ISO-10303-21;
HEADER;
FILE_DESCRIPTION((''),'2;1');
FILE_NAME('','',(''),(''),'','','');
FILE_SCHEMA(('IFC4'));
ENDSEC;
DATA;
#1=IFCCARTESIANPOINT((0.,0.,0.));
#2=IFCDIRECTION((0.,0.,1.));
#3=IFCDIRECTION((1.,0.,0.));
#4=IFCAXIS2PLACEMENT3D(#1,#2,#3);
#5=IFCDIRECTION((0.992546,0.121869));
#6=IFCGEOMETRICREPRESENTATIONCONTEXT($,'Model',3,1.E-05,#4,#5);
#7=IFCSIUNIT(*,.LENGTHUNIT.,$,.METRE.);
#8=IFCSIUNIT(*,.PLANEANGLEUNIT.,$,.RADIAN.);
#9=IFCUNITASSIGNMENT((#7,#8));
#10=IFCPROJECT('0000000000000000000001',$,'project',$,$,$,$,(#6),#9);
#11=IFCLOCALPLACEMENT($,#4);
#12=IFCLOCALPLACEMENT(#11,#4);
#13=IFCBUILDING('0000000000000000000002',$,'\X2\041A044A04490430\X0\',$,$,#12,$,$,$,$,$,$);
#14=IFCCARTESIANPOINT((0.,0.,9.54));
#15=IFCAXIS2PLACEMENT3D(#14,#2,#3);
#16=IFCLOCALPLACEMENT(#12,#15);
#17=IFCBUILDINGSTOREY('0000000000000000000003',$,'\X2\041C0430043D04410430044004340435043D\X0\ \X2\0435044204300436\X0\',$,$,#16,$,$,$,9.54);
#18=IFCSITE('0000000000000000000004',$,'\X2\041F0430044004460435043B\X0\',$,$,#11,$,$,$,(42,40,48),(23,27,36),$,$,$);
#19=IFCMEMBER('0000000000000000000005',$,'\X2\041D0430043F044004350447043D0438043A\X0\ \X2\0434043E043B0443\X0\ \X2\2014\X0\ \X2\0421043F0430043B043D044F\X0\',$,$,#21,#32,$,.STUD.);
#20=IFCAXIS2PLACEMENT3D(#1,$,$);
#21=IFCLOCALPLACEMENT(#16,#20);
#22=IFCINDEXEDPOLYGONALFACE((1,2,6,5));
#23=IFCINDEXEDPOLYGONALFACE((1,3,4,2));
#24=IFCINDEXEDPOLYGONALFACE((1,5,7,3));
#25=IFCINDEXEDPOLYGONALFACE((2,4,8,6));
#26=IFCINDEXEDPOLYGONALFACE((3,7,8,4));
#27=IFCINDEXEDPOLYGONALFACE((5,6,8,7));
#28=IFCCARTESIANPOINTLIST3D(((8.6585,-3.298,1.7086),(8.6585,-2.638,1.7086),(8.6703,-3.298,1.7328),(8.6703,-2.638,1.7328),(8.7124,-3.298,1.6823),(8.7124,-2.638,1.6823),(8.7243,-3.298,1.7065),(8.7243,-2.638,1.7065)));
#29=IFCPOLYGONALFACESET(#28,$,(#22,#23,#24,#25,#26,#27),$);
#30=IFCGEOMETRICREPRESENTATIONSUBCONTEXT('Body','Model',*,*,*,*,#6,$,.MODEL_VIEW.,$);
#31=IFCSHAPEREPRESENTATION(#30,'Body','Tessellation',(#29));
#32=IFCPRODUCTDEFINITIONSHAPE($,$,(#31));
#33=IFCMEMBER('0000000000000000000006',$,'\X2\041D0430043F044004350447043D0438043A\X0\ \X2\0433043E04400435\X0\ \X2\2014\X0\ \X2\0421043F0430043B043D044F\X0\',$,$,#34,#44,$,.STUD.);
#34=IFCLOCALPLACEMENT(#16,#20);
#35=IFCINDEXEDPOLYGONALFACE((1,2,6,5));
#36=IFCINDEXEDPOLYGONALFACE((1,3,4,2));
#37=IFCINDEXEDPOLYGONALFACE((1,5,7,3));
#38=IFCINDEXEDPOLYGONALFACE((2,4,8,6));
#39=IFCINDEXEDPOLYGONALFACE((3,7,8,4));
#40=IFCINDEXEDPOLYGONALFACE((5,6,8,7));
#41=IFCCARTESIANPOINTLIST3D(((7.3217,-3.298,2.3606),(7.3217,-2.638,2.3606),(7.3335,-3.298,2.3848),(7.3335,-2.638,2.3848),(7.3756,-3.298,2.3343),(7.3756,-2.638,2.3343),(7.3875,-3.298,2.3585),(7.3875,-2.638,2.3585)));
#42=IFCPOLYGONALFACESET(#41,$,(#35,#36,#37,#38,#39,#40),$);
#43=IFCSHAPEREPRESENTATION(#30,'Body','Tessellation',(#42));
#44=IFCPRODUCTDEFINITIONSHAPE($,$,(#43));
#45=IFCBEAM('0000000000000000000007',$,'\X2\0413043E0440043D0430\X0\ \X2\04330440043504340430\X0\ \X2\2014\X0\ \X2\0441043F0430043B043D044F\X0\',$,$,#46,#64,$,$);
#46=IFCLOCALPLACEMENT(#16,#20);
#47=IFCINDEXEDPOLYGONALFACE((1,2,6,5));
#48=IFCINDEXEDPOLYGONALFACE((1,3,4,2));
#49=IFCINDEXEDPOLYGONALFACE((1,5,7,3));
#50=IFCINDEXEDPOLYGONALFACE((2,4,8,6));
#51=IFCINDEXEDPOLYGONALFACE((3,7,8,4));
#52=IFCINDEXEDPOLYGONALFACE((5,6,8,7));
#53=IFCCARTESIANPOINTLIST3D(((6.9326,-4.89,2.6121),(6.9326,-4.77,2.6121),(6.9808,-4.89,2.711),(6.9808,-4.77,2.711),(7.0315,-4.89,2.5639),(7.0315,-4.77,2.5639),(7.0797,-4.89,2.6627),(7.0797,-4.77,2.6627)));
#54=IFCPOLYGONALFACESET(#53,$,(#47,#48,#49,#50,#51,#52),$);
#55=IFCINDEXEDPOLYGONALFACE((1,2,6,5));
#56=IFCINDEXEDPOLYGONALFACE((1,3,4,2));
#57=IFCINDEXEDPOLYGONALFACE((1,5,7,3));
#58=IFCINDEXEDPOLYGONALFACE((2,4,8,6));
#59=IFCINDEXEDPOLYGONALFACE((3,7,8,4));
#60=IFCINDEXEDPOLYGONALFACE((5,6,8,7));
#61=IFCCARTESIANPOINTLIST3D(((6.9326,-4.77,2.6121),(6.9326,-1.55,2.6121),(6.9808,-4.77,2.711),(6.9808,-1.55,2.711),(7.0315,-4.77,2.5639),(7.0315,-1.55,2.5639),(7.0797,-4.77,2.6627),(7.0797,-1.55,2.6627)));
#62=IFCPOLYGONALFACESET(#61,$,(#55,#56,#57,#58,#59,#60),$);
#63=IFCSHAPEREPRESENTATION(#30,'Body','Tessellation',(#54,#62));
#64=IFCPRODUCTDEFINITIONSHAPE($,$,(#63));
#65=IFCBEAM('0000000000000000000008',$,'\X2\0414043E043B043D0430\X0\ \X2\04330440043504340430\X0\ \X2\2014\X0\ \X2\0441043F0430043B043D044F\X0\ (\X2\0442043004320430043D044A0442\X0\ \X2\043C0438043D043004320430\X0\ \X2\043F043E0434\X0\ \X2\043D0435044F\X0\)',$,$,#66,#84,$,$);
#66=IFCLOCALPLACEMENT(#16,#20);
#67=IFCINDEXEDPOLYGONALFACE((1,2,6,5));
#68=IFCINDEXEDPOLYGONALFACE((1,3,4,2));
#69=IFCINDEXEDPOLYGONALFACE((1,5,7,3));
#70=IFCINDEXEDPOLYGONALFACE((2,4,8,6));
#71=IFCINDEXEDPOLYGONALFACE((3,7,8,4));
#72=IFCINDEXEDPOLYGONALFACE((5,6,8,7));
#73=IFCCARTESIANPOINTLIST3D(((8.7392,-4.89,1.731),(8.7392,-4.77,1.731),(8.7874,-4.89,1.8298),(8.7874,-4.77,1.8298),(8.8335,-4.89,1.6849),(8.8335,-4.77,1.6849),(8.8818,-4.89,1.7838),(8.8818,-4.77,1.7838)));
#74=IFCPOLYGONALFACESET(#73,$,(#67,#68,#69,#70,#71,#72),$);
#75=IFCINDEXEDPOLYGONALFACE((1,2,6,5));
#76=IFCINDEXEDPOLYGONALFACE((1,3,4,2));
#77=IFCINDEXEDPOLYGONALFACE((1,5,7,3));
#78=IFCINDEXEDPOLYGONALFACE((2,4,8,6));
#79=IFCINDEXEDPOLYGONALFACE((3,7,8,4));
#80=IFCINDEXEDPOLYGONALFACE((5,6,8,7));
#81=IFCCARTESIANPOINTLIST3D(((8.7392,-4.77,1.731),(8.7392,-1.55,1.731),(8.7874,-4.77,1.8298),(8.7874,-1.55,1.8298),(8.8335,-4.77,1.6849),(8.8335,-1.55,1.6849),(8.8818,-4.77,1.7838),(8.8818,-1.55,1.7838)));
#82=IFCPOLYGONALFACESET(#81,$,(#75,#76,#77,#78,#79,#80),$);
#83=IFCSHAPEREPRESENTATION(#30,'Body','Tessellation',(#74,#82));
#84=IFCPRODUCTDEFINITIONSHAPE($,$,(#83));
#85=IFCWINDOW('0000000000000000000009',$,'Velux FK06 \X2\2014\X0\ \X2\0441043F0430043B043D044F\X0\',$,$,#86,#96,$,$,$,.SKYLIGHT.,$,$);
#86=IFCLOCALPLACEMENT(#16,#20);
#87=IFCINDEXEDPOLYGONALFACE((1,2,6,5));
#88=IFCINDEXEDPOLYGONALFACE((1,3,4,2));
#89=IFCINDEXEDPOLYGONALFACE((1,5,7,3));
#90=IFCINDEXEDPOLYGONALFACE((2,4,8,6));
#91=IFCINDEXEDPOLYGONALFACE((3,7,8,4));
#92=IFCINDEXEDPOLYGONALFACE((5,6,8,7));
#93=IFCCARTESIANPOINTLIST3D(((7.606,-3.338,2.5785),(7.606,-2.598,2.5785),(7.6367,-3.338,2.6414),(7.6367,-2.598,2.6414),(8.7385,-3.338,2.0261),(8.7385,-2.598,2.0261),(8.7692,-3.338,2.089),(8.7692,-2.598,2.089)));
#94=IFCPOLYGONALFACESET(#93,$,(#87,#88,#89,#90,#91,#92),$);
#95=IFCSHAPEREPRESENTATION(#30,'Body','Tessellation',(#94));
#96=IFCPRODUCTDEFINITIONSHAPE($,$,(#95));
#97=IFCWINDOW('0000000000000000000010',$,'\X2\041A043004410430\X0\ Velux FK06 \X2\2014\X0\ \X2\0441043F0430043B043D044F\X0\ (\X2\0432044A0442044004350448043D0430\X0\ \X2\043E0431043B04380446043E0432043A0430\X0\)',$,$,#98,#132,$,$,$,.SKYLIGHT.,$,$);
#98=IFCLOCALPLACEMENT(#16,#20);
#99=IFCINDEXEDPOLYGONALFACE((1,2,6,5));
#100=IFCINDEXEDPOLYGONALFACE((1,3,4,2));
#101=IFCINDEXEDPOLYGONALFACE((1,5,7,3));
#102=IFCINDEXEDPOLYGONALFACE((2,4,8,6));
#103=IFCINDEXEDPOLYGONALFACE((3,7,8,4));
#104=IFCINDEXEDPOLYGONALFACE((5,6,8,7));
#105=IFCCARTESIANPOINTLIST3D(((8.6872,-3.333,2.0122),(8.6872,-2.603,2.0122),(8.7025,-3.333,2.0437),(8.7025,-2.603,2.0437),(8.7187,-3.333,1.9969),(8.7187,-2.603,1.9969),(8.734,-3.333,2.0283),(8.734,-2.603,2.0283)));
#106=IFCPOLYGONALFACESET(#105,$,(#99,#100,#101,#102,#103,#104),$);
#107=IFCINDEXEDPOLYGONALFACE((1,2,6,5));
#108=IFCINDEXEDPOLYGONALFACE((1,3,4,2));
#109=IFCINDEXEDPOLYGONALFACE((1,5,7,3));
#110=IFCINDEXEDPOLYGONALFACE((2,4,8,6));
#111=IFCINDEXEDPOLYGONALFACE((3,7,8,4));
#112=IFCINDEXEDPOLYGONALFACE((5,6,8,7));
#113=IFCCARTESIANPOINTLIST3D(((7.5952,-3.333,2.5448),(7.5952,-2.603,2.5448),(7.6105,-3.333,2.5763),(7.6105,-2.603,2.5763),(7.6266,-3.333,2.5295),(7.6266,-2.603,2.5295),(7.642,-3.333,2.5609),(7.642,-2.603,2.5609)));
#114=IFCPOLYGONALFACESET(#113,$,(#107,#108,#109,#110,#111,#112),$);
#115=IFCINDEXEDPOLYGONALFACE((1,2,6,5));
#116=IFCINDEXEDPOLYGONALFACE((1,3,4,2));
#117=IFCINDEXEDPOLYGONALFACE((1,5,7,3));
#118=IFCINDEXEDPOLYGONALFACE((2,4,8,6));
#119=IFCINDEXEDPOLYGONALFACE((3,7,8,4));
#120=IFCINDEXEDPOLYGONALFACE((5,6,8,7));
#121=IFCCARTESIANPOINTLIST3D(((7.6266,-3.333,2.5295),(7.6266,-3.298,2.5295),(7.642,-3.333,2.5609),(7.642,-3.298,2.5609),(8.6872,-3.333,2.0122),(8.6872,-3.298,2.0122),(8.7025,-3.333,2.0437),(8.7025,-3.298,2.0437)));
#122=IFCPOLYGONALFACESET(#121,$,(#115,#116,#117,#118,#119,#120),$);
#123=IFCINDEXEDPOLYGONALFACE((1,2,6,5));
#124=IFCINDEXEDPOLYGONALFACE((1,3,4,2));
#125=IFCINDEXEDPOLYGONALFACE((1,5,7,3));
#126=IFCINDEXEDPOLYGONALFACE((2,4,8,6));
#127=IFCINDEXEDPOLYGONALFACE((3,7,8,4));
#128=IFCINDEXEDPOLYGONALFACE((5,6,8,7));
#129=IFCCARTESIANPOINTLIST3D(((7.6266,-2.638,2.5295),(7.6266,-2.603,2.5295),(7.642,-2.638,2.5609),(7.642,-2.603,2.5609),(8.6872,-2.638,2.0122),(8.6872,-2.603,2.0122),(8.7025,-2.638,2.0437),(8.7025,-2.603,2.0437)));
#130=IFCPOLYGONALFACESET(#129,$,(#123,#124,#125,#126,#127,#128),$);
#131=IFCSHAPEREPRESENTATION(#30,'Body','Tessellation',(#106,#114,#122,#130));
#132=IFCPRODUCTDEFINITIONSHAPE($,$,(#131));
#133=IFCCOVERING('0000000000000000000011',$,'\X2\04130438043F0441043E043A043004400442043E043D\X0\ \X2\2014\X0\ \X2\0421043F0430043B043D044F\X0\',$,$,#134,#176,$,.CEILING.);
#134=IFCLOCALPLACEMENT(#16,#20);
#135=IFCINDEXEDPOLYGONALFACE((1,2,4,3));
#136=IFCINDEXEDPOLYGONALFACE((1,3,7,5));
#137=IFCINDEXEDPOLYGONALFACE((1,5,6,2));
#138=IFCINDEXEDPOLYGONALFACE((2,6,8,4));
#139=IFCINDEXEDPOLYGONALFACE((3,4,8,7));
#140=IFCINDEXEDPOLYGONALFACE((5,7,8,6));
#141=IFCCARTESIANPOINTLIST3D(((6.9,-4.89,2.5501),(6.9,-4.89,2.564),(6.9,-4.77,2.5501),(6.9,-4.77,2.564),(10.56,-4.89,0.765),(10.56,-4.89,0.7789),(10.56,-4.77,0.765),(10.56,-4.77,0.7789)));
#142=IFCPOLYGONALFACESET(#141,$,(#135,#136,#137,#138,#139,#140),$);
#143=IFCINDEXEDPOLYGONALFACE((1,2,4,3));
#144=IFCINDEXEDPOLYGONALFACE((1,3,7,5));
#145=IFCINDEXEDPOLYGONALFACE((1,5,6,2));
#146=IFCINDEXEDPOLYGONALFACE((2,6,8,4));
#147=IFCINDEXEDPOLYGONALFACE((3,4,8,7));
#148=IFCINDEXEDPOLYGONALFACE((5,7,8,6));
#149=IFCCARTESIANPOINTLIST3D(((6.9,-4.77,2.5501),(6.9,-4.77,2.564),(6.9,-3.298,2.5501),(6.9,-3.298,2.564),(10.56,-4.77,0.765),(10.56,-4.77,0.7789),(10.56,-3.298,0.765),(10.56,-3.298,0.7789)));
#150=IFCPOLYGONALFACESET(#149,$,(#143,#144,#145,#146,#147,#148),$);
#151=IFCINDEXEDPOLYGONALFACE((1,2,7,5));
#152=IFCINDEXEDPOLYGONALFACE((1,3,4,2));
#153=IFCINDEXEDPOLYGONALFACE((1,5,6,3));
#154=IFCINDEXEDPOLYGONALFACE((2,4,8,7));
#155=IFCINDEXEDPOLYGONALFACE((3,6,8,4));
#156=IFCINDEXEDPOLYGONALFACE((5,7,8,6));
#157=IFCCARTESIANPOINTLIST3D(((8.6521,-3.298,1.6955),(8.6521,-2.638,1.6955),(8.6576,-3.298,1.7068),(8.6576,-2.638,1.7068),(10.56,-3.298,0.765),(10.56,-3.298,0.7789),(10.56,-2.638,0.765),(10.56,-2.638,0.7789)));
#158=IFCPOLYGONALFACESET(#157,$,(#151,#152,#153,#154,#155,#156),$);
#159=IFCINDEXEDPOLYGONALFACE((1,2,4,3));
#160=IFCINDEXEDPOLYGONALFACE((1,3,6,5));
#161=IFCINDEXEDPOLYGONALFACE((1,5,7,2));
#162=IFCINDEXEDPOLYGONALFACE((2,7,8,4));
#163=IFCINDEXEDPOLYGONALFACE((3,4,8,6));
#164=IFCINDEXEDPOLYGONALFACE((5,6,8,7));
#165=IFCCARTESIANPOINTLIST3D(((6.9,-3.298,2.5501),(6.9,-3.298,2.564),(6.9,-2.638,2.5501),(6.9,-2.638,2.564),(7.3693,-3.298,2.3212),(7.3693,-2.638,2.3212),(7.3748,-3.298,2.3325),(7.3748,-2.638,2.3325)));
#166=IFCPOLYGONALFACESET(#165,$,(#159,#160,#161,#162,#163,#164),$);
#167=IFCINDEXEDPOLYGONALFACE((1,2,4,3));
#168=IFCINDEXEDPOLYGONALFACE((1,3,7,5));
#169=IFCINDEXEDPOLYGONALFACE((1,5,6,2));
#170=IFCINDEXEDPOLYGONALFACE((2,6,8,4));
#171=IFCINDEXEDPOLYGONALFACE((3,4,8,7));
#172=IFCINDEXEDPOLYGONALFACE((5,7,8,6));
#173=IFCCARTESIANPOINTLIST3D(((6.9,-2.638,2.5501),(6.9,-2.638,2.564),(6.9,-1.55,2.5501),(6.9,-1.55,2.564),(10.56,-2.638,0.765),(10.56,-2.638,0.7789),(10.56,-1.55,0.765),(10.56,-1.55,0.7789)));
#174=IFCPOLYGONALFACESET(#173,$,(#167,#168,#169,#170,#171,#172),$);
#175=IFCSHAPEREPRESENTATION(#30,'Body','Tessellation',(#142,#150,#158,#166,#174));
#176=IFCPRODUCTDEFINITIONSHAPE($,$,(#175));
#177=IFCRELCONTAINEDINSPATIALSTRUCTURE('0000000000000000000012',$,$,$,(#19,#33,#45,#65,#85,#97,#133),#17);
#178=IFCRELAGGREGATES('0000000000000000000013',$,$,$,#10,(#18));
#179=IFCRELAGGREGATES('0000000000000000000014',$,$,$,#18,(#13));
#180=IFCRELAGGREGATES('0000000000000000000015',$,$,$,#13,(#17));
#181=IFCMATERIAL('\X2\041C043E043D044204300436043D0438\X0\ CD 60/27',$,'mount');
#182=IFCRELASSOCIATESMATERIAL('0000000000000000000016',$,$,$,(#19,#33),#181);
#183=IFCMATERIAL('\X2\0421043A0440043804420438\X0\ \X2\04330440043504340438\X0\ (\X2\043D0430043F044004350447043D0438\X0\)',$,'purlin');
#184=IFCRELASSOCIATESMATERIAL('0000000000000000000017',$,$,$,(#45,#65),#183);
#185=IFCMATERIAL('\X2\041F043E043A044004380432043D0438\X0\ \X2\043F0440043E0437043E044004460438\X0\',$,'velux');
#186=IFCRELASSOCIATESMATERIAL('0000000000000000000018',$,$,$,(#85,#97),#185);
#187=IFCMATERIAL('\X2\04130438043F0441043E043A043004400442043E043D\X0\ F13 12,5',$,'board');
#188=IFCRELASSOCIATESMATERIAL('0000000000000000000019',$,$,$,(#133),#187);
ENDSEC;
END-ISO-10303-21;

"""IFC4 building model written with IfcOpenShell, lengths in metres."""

from ifc_helpers import new_model, si_unit, direction, frame, origin_with_axes, place, context, subcontext, project, spatial, polyline, outline, extrude, material, element, save


model = new_model("IFC4")

# Units and contexts
model_context = context("Model", 3, precision=1e-05, world=origin_with_axes(), true_north=direction((0.992546, 0.121869)))
body_context = subcontext(model_context, "Body", "Model", "MODEL_VIEW")
ifc_project = project(units=[si_unit("LENGTHUNIT", "METRE"), si_unit("PLANEANGLEUNIT", "RADIAN")], contexts=[model_context])

# Site, building, storey
site_placement = place(None, origin_with_axes())
site = spatial("IfcSite", under=ifc_project, at=site_placement, Name="Парцел", RefLatitude=(42, 40, 48), RefLongitude=(23, 27, 36))
building_placement = place(site_placement, origin_with_axes())
building = spatial("IfcBuilding", under=site, at=building_placement, Name="Къща")
storey_placement = place(building_placement, frame((0.0, 0.0, 9.54), z_axis=(0.0, 0.0, 1.0), x_axis=(1.0, 0.0, 0.0)))
storey = spatial("IfcBuildingStorey", under=building, at=storey_placement, Name="Мансарден етаж", Elevation=9.54)

# Members
ifc_material_1 = material(Name="Монтажни CD 60/27", Category="mount")
member_1_placement = place(storey_placement, origin_with_axes())
element("IfcMember", 1, at=member_1_placement, inside=storey, material=ifc_material_1, Name="Напречник долу — Спалня", PredefinedType="STUD", context=body_context, shape_type="SweptSolid", body=[
    extrude(outline(polyline([(8.7124, -1.6823), (8.6585, -1.7086), (8.6703, -1.7328), (8.7243, -1.7065), (8.7124, -1.6823)])), frame((0.0, -3.298, 0.0), z_axis=(0.0, 1.0, 0.0), x_axis=(1.0, 0.0, 0.0)), (0.0, 0.0, 1.0), 0.66),
])
member_2_placement = place(storey_placement, origin_with_axes())
element("IfcMember", 2, at=member_2_placement, inside=storey, material=ifc_material_1, Name="Напречник горе — Спалня", PredefinedType="STUD", context=body_context, shape_type="SweptSolid", body=[
    extrude(outline(polyline([(7.3756, -2.3342), (7.3217, -2.3606), (7.3335, -2.3848), (7.3875, -2.3585), (7.3756, -2.3342)])), frame((0.0, -3.298, 0.0), z_axis=(0.0, 1.0, 0.0), x_axis=(1.0, 0.0, 0.0)), (0.0, 0.0, 1.0), 0.66),
])

# Beams
ifc_material_2 = material(Name="Скрити греди (напречни)", Category="purlin")
beam_1_placement = place(storey_placement, origin_with_axes())
element("IfcBeam", 3, at=beam_1_placement, inside=storey, material=ifc_material_2, Name="Горна греда — спалня", context=body_context, shape_type="SweptSolid", body=[
    extrude(outline(polyline([(7.0315, -2.5639), (6.9326, -2.6121), (6.9808, -2.711), (7.0797, -2.6627), (7.0315, -2.5639)])), frame((0.0, -4.89, 0.0), z_axis=(0.0, 1.0, 0.0), x_axis=(1.0, 0.0, 0.0)), (0.0, 0.0, 1.0), 0.12),
    extrude(outline(polyline([(7.0315, -2.5639), (6.9326, -2.6121), (6.9808, -2.711), (7.0797, -2.6627), (7.0315, -2.5639)])), frame((0.0, -4.77, 0.0), z_axis=(0.0, 1.0, 0.0), x_axis=(1.0, 0.0, 0.0)), (0.0, 0.0, 1.0), 3.22),
])
beam_2_placement = place(storey_placement, origin_with_axes())
element("IfcBeam", 4, at=beam_2_placement, inside=storey, material=ifc_material_2, Name="Долна греда — спалня (таванът минава под нея)", context=body_context, shape_type="SweptSolid", body=[
    extrude(outline(polyline([(8.8335, -1.6849), (8.7392, -1.731), (8.7874, -1.8298), (8.8818, -1.7838), (8.8335, -1.6849)])), frame((0.0, -4.89, 0.0), z_axis=(0.0, 1.0, 0.0), x_axis=(1.0, 0.0, 0.0)), (0.0, 0.0, 1.0), 0.12),
    extrude(outline(polyline([(8.8335, -1.6849), (8.7392, -1.731), (8.7874, -1.8298), (8.8818, -1.7838), (8.8335, -1.6849)])), frame((0.0, -4.77, 0.0), z_axis=(0.0, 1.0, 0.0), x_axis=(1.0, 0.0, 0.0)), (0.0, 0.0, 1.0), 3.22),
])

# Windows
ifc_material_3 = material(Name="Покривни прозорци", Category="velux")
window_1_placement = place(storey_placement, origin_with_axes())
element("IfcWindow", 5, at=window_1_placement, inside=storey, material=ifc_material_3, Name="Velux FK06 — спалня", PredefinedType="SKYLIGHT", context=body_context, shape_type="SweptSolid", body=[
    extrude(outline(polyline([(8.7385, -2.0261), (7.606, -2.5785), (7.6367, -2.6414), (8.7692, -2.089), (8.7385, -2.0261)])), frame((0.0, -3.338, 0.0), z_axis=(0.0, 1.0, 0.0), x_axis=(1.0, 0.0, 0.0)), (0.0, 0.0, 1.0), 0.74),
])
window_2_placement = place(storey_placement, origin_with_axes())
element("IfcWindow", 6, at=window_2_placement, inside=storey, material=ifc_material_3, Name="Каса Velux FK06 — спалня (вътрешна облицовка)", PredefinedType="SKYLIGHT", context=body_context, shape_type="SweptSolid", body=[
    extrude(outline(polyline([(8.7187, -1.9969), (8.6872, -2.0122), (8.7025, -2.0437), (8.734, -2.0283), (8.7187, -1.9969)])), frame((0.0, -3.333, 0.0), z_axis=(0.0, 1.0, 0.0), x_axis=(1.0, 0.0, 0.0)), (0.0, 0.0, 1.0), 0.73),
    extrude(outline(polyline([(7.6266, -2.5295), (7.5952, -2.5448), (7.6105, -2.5763), (7.642, -2.5609), (7.6266, -2.5295)])), frame((0.0, -3.333, 0.0), z_axis=(0.0, 1.0, 0.0), x_axis=(1.0, 0.0, 0.0)), (0.0, 0.0, 1.0), 0.73),
    extrude(outline(polyline([(8.6872, -2.0122), (7.6266, -2.5295), (7.642, -2.5609), (8.7025, -2.0437), (8.6872, -2.0122)])), frame((0.0, -3.333, 0.0), z_axis=(0.0, 1.0, 0.0), x_axis=(1.0, 0.0, 0.0)), (0.0, 0.0, 1.0), 0.035),
    extrude(outline(polyline([(8.6872, -2.0122), (7.6266, -2.5295), (7.642, -2.5609), (8.7025, -2.0437), (8.6872, -2.0122)])), frame((0.0, -2.638, 0.0), z_axis=(0.0, 1.0, 0.0), x_axis=(1.0, 0.0, 0.0)), (0.0, 0.0, 1.0), 0.035),
])

# Covering
ifc_material_4 = material(Name="Гипсокартон F13 12,5", Category="board")
covering_1_placement = place(storey_placement, origin_with_axes())
element("IfcCovering", 7, at=covering_1_placement, inside=storey, material=ifc_material_4, Name="Гипсокартон — Спалня", PredefinedType="CEILING", context=body_context, shape_type="SweptSolid", body=[
    extrude(outline(polyline([(10.56, -0.765), (6.9, -2.5501), (6.9, -2.564), (10.56, -0.7789), (10.56, -0.765)])), frame((0.0, -4.89, 0.0), z_axis=(0.0, 1.0, 0.0), x_axis=(1.0, 0.0, 0.0)), (0.0, 0.0, 1.0), 0.12),
    extrude(outline(polyline([(10.56, -0.765), (6.9, -2.5501), (6.9, -2.564), (10.56, -0.7789), (10.56, -0.765)])), frame((0.0, -4.77, 0.0), z_axis=(0.0, 1.0, 0.0), x_axis=(1.0, 0.0, 0.0)), (0.0, 0.0, 1.0), 1.472),
    extrude(outline(polyline([(10.56, -0.765), (8.6521, -1.6955), (8.6576, -1.7068), (10.56, -0.7789), (10.56, -0.765)])), frame((0.0, -3.298, 0.0), z_axis=(0.0, 1.0, 0.0), x_axis=(1.0, 0.0, 0.0)), (0.0, 0.0, 1.0), 0.66),
    extrude(outline(polyline([(7.3693, -2.3212), (6.9, -2.5501), (6.9, -2.564), (7.3748, -2.3325), (7.3693, -2.3212)])), frame((0.0, -3.298, 0.0), z_axis=(0.0, 1.0, 0.0), x_axis=(1.0, 0.0, 0.0)), (0.0, 0.0, 1.0), 0.66),
    extrude(outline(polyline([(10.56, -0.765), (6.9, -2.5501), (6.9, -2.564), (10.56, -0.7789), (10.56, -0.765)])), frame((0.0, -2.638, 0.0), z_axis=(0.0, 1.0, 0.0), x_axis=(1.0, 0.0, 0.0)), (0.0, 0.0, 1.0), 1.088),
])

save(model, "model.ifc")
